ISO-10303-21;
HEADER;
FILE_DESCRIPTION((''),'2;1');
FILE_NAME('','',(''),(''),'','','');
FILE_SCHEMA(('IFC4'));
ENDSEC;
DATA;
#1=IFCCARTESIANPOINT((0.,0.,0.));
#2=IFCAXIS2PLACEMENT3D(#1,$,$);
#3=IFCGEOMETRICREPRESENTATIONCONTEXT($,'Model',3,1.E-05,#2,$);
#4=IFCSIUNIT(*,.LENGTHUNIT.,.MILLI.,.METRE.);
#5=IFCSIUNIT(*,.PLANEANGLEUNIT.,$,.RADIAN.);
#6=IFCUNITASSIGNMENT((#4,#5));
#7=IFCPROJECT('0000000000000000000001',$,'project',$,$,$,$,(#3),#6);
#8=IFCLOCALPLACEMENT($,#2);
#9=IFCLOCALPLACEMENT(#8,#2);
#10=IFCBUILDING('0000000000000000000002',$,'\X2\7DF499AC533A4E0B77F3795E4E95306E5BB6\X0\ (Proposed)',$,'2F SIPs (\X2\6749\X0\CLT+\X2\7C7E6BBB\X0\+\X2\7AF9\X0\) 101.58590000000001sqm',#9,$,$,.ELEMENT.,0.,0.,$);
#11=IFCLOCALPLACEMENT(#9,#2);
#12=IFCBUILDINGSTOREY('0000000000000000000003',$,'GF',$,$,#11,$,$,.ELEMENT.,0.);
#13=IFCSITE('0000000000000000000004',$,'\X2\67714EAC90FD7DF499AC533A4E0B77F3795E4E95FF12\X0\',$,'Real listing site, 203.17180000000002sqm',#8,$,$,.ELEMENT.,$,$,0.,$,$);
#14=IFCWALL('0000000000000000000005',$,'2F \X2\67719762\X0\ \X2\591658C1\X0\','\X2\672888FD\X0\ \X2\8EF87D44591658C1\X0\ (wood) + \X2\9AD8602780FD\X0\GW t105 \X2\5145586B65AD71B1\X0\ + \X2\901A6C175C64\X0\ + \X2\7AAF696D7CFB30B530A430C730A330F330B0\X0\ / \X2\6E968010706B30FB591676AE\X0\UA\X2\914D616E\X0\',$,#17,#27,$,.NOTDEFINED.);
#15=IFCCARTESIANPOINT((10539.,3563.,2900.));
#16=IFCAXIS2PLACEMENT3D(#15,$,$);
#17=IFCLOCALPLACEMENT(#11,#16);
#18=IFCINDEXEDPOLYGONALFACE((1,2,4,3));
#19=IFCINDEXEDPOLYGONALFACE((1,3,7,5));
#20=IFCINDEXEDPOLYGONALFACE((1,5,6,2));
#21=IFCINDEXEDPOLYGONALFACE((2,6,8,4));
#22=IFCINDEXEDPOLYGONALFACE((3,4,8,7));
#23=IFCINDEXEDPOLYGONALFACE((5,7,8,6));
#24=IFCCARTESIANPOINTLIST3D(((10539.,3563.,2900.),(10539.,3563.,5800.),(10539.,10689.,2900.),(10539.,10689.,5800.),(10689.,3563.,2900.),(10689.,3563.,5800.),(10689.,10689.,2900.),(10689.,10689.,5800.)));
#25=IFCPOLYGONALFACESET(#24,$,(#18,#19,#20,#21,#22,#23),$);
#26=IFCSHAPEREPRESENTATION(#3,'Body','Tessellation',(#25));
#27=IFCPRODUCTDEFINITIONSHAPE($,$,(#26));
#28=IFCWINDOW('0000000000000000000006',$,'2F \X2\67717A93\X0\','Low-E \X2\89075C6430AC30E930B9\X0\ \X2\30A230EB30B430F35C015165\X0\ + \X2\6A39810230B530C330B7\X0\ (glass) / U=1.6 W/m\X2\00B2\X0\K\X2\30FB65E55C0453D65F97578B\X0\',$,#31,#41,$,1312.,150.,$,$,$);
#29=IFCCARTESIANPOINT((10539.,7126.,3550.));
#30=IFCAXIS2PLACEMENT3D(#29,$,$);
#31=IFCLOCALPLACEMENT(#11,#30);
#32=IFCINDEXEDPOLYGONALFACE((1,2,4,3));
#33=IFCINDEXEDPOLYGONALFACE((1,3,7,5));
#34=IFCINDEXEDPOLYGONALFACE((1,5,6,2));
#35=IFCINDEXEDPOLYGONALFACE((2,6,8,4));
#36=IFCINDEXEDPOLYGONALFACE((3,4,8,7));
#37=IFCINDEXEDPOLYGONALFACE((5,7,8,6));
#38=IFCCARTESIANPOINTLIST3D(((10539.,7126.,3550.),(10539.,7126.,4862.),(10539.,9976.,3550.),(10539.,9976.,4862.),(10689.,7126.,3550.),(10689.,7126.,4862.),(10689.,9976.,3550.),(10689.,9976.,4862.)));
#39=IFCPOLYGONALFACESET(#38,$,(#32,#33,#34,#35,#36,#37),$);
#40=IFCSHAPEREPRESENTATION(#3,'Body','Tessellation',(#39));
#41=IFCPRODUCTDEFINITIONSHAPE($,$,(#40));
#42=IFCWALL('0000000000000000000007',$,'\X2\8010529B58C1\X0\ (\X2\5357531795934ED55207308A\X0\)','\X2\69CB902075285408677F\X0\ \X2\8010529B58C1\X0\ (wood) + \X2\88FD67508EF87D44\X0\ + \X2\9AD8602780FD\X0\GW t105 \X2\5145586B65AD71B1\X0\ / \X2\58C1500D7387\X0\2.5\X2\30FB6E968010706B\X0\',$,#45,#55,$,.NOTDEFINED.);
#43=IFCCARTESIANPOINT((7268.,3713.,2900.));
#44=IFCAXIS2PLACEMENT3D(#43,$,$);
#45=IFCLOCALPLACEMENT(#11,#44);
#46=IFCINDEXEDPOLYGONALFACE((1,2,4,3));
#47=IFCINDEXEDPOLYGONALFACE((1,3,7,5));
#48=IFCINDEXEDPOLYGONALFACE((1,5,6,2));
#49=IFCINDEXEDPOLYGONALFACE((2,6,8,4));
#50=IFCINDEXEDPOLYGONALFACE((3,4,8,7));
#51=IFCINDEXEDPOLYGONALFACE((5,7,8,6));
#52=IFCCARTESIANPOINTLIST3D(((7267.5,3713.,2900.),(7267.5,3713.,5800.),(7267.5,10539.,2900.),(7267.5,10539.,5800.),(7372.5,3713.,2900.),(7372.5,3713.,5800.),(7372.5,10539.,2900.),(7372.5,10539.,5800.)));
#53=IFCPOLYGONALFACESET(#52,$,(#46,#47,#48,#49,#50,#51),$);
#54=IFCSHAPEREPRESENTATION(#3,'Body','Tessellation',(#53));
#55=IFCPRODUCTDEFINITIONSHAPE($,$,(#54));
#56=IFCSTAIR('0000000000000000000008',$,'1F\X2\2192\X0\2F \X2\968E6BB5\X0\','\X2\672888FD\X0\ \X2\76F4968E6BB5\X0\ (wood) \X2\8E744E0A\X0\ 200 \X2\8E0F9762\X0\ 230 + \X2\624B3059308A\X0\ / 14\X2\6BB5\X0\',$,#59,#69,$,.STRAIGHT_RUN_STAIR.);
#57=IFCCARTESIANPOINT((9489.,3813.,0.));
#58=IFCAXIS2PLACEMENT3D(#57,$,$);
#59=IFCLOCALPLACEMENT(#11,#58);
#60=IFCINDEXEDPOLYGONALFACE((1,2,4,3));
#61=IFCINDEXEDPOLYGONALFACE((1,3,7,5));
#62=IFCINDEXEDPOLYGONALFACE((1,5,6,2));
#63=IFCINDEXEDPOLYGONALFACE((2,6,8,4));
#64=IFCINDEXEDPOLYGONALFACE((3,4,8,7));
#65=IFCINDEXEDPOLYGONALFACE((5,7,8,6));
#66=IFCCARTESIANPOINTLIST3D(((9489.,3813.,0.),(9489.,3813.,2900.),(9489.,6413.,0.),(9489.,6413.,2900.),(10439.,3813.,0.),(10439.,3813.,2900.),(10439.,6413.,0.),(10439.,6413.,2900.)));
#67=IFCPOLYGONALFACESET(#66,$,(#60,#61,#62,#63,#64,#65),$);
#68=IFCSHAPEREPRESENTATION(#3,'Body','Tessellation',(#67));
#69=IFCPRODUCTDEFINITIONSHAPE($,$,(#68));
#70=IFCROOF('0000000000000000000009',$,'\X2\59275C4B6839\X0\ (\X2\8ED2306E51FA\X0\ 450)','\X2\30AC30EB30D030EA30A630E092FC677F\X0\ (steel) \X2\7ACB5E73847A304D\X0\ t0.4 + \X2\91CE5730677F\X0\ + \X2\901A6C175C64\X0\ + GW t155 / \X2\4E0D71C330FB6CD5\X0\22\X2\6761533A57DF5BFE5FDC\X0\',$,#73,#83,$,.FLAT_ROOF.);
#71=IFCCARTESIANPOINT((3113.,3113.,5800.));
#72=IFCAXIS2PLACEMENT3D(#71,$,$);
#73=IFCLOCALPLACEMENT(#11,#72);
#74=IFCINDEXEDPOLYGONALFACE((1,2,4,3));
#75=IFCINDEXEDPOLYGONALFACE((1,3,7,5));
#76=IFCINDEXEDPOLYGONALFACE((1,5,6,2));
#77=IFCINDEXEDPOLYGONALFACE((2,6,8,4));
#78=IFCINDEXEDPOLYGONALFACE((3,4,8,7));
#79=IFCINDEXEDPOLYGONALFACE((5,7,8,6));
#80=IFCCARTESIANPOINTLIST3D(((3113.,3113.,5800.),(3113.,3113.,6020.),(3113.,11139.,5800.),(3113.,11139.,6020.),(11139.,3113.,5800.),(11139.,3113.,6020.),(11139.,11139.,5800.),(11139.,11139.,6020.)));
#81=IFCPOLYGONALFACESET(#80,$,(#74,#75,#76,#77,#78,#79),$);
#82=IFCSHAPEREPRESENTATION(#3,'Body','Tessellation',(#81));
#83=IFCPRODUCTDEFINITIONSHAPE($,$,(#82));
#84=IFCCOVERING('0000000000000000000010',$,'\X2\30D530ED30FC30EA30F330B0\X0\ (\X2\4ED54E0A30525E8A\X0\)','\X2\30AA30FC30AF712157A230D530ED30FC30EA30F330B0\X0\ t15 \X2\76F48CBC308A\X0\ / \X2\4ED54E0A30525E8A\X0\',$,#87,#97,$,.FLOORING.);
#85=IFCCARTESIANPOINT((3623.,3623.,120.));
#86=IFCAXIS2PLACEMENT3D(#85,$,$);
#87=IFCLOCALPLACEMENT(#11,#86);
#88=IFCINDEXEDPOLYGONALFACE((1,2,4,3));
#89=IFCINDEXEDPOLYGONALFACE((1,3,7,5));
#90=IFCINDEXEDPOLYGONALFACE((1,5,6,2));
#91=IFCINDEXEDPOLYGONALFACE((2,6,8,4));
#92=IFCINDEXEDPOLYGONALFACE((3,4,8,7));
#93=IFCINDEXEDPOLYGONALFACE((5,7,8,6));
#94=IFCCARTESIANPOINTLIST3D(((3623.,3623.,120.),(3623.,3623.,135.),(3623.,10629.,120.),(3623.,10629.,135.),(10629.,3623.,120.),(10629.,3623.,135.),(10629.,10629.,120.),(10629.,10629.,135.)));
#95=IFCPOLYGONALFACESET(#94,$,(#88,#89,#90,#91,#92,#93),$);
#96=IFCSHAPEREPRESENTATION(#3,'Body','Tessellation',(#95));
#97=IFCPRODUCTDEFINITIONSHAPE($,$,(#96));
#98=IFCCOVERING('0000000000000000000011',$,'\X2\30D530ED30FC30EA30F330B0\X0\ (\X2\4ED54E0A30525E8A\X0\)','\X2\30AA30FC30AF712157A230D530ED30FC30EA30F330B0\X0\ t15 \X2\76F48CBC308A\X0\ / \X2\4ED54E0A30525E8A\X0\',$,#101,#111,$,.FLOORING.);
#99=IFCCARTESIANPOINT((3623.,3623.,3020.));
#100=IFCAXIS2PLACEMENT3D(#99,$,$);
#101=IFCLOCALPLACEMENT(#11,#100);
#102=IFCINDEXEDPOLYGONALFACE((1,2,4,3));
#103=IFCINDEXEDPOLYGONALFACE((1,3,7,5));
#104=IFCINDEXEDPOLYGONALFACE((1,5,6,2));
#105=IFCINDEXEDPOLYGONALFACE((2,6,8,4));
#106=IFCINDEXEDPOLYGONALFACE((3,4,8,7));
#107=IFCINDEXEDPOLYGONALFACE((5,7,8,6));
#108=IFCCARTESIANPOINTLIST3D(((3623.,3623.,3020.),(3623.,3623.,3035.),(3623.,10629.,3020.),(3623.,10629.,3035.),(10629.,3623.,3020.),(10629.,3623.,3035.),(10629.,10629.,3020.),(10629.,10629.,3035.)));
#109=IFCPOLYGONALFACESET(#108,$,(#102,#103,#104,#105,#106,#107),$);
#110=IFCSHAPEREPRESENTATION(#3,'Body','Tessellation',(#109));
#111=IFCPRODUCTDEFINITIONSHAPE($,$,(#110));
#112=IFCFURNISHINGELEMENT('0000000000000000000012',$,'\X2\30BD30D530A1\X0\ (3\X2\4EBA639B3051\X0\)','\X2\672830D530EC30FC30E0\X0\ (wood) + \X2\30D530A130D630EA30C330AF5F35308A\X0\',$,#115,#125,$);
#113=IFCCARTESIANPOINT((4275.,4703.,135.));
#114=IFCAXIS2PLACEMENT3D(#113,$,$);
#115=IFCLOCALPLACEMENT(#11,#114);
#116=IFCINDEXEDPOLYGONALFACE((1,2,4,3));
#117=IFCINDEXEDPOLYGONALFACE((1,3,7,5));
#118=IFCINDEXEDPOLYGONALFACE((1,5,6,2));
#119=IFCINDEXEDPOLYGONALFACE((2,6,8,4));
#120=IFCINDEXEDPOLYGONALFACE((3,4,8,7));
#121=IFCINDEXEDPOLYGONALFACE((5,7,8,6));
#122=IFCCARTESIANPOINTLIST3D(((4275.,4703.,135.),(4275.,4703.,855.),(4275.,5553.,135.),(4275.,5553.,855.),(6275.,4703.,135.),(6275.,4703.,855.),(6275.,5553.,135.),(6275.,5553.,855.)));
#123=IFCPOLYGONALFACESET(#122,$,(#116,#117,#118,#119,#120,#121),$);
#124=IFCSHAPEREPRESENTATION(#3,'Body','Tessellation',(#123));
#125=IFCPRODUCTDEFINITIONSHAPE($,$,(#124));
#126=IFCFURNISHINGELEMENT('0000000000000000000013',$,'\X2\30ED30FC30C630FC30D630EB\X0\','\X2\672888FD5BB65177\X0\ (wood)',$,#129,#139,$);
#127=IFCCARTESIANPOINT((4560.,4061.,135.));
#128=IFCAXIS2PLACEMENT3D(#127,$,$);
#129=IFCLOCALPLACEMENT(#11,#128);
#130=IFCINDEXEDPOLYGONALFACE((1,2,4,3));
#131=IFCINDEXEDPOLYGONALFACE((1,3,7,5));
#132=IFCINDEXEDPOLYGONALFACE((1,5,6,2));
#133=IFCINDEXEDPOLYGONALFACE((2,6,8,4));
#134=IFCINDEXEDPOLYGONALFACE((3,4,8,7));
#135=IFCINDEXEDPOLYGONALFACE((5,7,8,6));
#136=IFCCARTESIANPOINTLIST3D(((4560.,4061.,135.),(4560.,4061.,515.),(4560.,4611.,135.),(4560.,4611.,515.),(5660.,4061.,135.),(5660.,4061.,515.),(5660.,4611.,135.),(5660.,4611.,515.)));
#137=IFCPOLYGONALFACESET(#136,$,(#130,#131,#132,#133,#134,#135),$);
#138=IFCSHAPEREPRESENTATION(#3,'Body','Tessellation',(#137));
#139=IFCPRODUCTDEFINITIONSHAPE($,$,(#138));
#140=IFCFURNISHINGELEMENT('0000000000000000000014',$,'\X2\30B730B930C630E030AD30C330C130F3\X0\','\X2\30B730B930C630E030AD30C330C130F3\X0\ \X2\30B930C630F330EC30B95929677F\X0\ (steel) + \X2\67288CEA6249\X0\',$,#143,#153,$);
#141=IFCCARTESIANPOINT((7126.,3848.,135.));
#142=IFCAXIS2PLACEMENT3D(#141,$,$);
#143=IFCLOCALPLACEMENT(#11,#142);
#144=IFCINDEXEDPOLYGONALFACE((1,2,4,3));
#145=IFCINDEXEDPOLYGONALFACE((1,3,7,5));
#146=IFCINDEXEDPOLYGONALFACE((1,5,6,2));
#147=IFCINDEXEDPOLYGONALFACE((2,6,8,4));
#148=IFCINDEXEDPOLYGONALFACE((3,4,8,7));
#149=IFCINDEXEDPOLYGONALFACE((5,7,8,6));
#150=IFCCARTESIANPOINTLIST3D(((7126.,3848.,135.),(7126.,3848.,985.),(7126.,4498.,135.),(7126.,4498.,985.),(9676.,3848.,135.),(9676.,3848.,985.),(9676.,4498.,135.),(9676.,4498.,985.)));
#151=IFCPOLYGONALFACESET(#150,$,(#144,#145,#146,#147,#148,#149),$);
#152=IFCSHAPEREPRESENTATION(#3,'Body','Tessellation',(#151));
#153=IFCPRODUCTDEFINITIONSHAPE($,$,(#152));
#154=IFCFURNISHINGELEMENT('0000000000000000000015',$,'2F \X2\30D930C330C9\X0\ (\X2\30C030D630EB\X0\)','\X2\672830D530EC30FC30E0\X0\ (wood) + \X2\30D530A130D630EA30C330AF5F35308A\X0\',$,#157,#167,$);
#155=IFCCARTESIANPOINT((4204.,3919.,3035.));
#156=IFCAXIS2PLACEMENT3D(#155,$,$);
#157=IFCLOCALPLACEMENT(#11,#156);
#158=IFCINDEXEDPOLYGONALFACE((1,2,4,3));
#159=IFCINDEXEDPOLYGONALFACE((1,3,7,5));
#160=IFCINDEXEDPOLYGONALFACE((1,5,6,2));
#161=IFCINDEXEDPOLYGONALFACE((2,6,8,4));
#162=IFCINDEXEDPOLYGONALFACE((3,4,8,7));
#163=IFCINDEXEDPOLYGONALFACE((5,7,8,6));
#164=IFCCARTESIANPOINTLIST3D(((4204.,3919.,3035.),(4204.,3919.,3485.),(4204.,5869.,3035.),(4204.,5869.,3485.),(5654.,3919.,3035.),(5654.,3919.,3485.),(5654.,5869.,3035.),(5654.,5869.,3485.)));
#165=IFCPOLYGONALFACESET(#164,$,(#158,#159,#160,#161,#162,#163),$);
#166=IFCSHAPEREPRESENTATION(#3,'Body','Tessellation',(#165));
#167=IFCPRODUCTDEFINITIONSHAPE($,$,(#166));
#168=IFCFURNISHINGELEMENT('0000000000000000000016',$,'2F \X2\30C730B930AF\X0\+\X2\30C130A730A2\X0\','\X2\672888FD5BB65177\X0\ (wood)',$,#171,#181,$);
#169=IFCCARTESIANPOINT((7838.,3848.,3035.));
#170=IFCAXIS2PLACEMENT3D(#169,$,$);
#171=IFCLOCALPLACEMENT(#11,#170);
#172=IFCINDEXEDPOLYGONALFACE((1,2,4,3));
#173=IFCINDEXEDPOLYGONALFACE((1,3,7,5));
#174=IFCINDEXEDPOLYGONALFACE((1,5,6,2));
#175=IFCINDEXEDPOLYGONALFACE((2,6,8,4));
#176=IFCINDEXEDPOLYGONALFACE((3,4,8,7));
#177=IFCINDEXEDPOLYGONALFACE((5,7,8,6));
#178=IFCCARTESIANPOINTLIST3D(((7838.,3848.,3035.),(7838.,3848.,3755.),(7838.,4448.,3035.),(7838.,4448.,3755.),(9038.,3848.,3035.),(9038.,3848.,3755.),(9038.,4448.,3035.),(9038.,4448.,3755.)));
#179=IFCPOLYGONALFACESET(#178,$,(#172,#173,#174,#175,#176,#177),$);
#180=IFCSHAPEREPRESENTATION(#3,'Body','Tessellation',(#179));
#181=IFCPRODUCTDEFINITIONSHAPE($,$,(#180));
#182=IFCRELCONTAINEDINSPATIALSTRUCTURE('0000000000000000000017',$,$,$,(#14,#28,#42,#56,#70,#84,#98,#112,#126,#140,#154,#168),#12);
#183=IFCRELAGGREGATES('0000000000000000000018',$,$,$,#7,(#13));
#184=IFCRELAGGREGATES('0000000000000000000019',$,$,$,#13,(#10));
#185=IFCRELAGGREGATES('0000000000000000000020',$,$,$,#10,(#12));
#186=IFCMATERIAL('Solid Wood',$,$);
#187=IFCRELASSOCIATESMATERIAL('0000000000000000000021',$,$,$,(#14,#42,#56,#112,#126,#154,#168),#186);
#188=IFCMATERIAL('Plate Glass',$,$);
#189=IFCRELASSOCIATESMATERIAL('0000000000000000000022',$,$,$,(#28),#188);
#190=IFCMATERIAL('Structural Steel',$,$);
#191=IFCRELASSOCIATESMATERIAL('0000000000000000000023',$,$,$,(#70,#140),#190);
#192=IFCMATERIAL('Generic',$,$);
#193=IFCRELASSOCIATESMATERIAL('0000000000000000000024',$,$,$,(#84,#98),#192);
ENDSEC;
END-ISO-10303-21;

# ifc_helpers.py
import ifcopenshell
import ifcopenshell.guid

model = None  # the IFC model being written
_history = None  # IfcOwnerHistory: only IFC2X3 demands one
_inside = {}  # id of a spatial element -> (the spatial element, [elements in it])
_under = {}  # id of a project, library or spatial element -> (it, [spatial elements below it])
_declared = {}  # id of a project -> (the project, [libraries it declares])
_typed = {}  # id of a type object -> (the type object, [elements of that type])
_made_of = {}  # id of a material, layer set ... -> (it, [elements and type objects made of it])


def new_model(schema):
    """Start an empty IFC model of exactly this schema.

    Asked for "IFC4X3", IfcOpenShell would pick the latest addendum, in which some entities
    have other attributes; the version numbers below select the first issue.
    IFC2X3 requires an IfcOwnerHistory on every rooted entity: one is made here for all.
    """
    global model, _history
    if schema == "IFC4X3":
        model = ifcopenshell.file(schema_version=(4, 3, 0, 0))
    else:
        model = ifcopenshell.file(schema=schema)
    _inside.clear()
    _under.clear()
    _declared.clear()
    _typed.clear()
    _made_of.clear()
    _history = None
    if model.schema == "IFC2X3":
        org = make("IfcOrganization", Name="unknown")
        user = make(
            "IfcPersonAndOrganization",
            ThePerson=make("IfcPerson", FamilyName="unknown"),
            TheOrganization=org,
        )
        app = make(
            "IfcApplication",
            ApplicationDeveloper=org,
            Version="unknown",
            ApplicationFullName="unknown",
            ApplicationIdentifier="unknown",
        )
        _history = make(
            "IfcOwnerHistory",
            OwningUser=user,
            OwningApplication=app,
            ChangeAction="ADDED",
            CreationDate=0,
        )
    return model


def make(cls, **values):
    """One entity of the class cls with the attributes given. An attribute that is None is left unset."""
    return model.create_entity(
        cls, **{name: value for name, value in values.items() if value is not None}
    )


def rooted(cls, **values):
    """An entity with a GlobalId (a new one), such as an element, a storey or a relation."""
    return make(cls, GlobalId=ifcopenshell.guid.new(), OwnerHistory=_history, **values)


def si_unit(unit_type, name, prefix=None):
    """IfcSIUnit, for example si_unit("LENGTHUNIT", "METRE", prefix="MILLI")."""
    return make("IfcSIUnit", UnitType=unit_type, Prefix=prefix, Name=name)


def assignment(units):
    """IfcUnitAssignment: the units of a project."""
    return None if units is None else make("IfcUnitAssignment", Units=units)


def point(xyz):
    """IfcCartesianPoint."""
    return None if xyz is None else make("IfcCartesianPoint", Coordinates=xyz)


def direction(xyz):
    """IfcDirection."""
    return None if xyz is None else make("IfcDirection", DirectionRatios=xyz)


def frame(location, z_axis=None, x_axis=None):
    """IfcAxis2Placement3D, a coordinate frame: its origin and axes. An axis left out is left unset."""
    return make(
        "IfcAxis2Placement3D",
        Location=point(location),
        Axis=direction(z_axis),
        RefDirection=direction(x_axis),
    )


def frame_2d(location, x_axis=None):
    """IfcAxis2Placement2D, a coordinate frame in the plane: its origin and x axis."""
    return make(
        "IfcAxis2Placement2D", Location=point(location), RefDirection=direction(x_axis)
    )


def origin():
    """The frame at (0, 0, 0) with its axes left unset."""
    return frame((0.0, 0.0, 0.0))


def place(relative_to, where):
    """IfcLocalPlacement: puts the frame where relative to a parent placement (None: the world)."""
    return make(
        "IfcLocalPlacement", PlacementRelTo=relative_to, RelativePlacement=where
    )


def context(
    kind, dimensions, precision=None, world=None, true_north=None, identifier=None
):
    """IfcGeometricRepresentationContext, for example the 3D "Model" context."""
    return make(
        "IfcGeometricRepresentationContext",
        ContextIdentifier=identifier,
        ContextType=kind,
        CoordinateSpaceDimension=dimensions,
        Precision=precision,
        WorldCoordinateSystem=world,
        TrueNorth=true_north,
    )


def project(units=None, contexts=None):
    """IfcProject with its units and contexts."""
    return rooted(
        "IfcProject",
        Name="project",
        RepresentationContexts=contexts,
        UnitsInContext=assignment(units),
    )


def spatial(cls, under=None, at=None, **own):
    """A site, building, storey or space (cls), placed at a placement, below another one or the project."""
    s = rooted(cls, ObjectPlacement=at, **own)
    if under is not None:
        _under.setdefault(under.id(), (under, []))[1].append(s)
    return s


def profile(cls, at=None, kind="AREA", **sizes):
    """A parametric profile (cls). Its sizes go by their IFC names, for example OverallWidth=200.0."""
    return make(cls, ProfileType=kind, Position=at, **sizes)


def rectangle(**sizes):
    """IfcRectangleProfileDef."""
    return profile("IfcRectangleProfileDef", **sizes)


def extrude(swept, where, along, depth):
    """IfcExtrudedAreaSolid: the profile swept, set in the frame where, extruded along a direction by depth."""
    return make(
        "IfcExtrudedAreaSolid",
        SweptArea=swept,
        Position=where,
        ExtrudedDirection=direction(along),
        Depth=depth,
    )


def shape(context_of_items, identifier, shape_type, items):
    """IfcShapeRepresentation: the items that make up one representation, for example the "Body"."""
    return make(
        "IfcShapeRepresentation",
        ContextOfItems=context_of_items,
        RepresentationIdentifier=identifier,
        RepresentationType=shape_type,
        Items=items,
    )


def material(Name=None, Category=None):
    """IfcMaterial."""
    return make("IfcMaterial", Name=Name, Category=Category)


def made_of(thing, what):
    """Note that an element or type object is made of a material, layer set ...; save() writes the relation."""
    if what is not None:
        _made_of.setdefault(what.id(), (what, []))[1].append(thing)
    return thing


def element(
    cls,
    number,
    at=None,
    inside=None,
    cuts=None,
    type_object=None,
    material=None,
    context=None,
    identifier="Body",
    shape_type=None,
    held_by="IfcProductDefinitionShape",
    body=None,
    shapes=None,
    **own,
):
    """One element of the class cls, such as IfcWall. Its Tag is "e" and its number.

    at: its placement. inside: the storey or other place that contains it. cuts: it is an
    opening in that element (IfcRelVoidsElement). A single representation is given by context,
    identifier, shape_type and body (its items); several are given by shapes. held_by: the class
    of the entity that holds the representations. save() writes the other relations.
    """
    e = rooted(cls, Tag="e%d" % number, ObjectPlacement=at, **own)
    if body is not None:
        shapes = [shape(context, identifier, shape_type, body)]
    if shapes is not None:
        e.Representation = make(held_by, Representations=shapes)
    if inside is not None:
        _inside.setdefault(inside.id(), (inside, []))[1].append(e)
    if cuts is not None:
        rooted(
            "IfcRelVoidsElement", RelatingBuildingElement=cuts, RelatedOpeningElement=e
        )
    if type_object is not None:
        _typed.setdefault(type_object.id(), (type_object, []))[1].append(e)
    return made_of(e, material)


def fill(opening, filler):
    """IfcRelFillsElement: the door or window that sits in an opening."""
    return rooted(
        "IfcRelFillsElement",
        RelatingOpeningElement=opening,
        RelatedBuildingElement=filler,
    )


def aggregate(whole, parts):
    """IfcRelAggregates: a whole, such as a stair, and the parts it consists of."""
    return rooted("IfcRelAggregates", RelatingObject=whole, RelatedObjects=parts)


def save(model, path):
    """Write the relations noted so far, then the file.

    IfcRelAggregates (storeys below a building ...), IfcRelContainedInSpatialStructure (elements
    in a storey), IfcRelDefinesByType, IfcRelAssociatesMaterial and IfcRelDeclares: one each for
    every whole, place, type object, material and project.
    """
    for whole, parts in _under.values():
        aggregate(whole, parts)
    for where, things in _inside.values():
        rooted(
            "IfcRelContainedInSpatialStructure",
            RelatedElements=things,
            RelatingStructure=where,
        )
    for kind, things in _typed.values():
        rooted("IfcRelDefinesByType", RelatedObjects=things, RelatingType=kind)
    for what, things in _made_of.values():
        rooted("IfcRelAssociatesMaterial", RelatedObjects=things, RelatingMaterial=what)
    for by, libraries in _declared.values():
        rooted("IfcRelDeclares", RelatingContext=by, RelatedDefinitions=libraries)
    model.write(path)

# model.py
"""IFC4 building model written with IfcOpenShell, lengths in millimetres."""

from ifc_helpers import new_model, si_unit, frame, frame_2d, origin, place, context, project, spatial, rectangle, extrude, material, element, fill, save


model = new_model("IFC4")

# Units and contexts
model_context = context("Model", 3, precision=1e-05, world=origin())
ifc_project = project(units=[si_unit("LENGTHUNIT", "METRE", prefix="MILLI"), si_unit("PLANEANGLEUNIT", "RADIAN")], contexts=[model_context])

# Site, building, storey
site_placement = place(None, origin())
site = spatial("IfcSite", under=ifc_project, at=site_placement, Name="東京都練馬区下石神井２", ObjectType="Real listing site, 203.17180000000002sqm", CompositionType="ELEMENT", RefElevation=0.0)
building_placement = place(site_placement, origin())
building = spatial("IfcBuilding", under=site, at=building_placement, Name="練馬区下石神井の家 (Proposed)", ObjectType="2F SIPs (杉CLT+籾殻+竹) 101.58590000000001sqm", CompositionType="ELEMENT", ElevationOfRefHeight=0.0, ElevationOfTerrain=0.0)
storey_placement = place(building_placement, origin())
storey = spatial("IfcBuildingStorey", under=building, at=storey_placement, Name="GF", CompositionType="ELEMENT", Elevation=0.0)

# Shared definitions
ifc_material_1 = material(Name="Solid Wood")

# Shared definitions
ifc_material_2 = material(Name="Plate Glass")

# Wall, opening, window
wall_1_placement = place(storey_placement, frame((10539.0, 3563.0, 2900.0)))
wall_1 = element("IfcWall", 1, at=wall_1_placement, inside=storey, material=ifc_material_1, Name="2F 東面 外壁", Description="木製 軸組外壁 (wood) + 高性能GW t105 充填断熱 + 通気層 + 窯業系サイディング / 準耐火・外皮UA配慮", PredefinedType="NOTDEFINED", context=model_context, shape_type="SweptSolid", body=[
    extrude(rectangle(XDim=150.0, YDim=7126.0, at=frame_2d((75.0, 3563.0))), frame((10539.0, 3563.0, 2900.0)), (0.0, 0.0, 1.0), 2900.0),
])
opening_1_placement = place(storey_placement, frame((10539.0, 7126.0, 3550.0)))
opening_1 = element("IfcOpeningElement", 2, at=opening_1_placement, cuts=wall_1, PredefinedType="NOTDEFINED", context=model_context, shape_type="SweptSolid", body=[
    extrude(rectangle(XDim=150.0, YDim=2850.0, at=frame_2d((75.0, 1425.0))), frame((10539.0, 7126.0, 3550.0)), (0.0, 0.0, 1.0), 1312.0),
])
window_1_placement = place(storey_placement, frame((10539.0, 7126.0, 3550.0)))
window_1 = element("IfcWindow", 3, at=window_1_placement, inside=storey, material=ifc_material_2, Name="2F 東窓", Description="Low-E 複層ガラス アルゴン封入 + 樹脂サッシ (glass) / U=1.6 W/m²K・日射取得型", OverallHeight=1312.0, OverallWidth=150.0, context=model_context, shape_type="SweptSolid", body=[
    extrude(rectangle(XDim=150.0, YDim=2850.0, at=frame_2d((75.0, 1425.0))), frame((10539.0, 7126.0, 3550.0)), (0.0, 0.0, 1.0), 1312.0),
])
fill(opening_1, window_1)

# Wall
wall_2_placement = place(storey_placement, frame((7268.0, 3713.0, 2900.0)))
element("IfcWall", 4, at=wall_2_placement, inside=storey, material=ifc_material_1, Name="耐力壁 (南北間仕切り)", Description="構造用合板 耐力壁 (wood) + 製材軸組 + 高性能GW t105 充填断熱 / 壁倍率2.5・準耐火", PredefinedType="NOTDEFINED", context=model_context, shape_type="SweptSolid", body=[
    extrude(rectangle(XDim=105.0, YDim=6826.0, at=frame_2d((52.0, 3413.0))), frame((7268.0, 3713.0, 2900.0)), (0.0, 0.0, 1.0), 2900.0),
])

# Stair
stair_placement = place(storey_placement, frame((9489.0, 3813.0, 0.0)))
element("IfcStair", 5, at=stair_placement, inside=storey, material=ifc_material_1, Name="1F→2F 階段", Description="木製 直階段 (wood) 蹴上 200 踏面 230 + 手すり / 14段", PredefinedType="STRAIGHT_RUN_STAIR", context=model_context, shape_type="SweptSolid", body=[
    extrude(rectangle(XDim=950.0, YDim=2600.0, at=frame_2d((475.0, 1300.0))), frame((9489.0, 3813.0, 0.0)), (0.0, 0.0, 1.0), 2900.0),
])

# Roof
ifc_material_3 = material(Name="Structural Steel")
roof_placement = place(storey_placement, frame((3113.0, 3113.0, 5800.0)))
element("IfcRoof", 6, at=roof_placement, inside=storey, material=ifc_material_3, Name="大屋根 (軒の出 450)", Description="ガルバリウム鋼板 (steel) 立平葺き t0.4 + 野地板 + 通気層 + GW t155 / 不燃・法22条区域対応", PredefinedType="FLAT_ROOF", context=model_context, shape_type="SweptSolid", body=[
    extrude(rectangle(XDim=8026.0, YDim=8026.0, at=frame_2d((4013.0, 4013.0))), frame((3113.0, 3113.0, 5800.0)), (0.0, 0.0, 1.0), 220.0),
])

# Coverings
ifc_material_4 = material(Name="Generic")
covering_1_placement = place(storey_placement, frame((3623.0, 3623.0, 120.0)))
element("IfcCovering", 7, at=covering_1_placement, inside=storey, material=ifc_material_4, Name="フローリング (仕上げ床)", Description="オーク無垢フローリング t15 直貼り / 仕上げ床", PredefinedType="FLOORING", context=model_context, shape_type="SweptSolid", body=[
    extrude(rectangle(XDim=7006.0, YDim=7006.0, at=frame_2d((3503.0, 3503.0))), frame((3623.0, 3623.0, 120.0)), (0.0, 0.0, 1.0), 15.0),
])
covering_2_placement = place(storey_placement, frame((3623.0, 3623.0, 3020.0)))
element("IfcCovering", 8, at=covering_2_placement, inside=storey, material=ifc_material_4, Name="フローリング (仕上げ床)", Description="オーク無垢フローリング t15 直貼り / 仕上げ床", PredefinedType="FLOORING", context=model_context, shape_type="SweptSolid", body=[
    extrude(rectangle(XDim=7006.0, YDim=7006.0, at=frame_2d((3503.0, 3503.0))), frame((3623.0, 3623.0, 3020.0)), (0.0, 0.0, 1.0), 15.0),
])

# Furnishing elements
furnishing_1_placement = place(storey_placement, frame((4275.0, 4703.0, 135.0)))
element("IfcFurnishingElement", 9, at=furnishing_1_placement, inside=storey, material=ifc_material_1, Name="ソファ (3人掛け)", Description="木フレーム (wood) + ファブリック張り", context=model_context, shape_type="SweptSolid", body=[
    extrude(rectangle(XDim=2000.0, YDim=850.0, at=frame_2d((1000.0, 425.0))), frame((4275.0, 4703.0, 135.0)), (0.0, 0.0, 1.0), 720.0),
])
furnishing_2_placement = place(storey_placement, frame((4560.0, 4061.0, 135.0)))
element("IfcFurnishingElement", 10, at=furnishing_2_placement, inside=storey, material=ifc_material_1, Name="ローテーブル", Description="木製家具 (wood)", context=model_context, shape_type="SweptSolid", body=[
    extrude(rectangle(XDim=1100.0, YDim=550.0, at=frame_2d((550.0, 275.0))), frame((4560.0, 4061.0, 135.0)), (0.0, 0.0, 1.0), 380.0),
])
furnishing_3_placement = place(storey_placement, frame((7126.0, 3848.0, 135.0)))
element("IfcFurnishingElement", 11, at=furnishing_3_placement, inside=storey, material=ifc_material_3, Name="システムキッチン", Description="システムキッチン ステンレス天板 (steel) + 木質扉", context=model_context, shape_type="SweptSolid", body=[
    extrude(rectangle(XDim=2550.0, YDim=650.0, at=frame_2d((1275.0, 325.0))), frame((7126.0, 3848.0, 135.0)), (0.0, 0.0, 1.0), 850.0),
])
furnishing_4_placement = place(storey_placement, frame((4204.0, 3919.0, 3035.0)))
element("IfcFurnishingElement", 12, at=furnishing_4_placement, inside=storey, material=ifc_material_1, Name="2F ベッド (ダブル)", Description="木フレーム (wood) + ファブリック張り", context=model_context, shape_type="SweptSolid", body=[
    extrude(rectangle(XDim=1450.0, YDim=1950.0, at=frame_2d((725.0, 975.0))), frame((4204.0, 3919.0, 3035.0)), (0.0, 0.0, 1.0), 450.0),
])
furnishing_5_placement = place(storey_placement, frame((7838.0, 3848.0, 3035.0)))
element("IfcFurnishingElement", 13, at=furnishing_5_placement, inside=storey, material=ifc_material_1, Name="2F デスク+チェア", Description="木製家具 (wood)", context=model_context, shape_type="SweptSolid", body=[
    extrude(rectangle(XDim=1200.0, YDim=600.0, at=frame_2d((600.0, 300.0))), frame((7838.0, 3848.0, 3035.0)), (0.0, 0.0, 1.0), 720.0),
])

save(model, "model.ifc")
